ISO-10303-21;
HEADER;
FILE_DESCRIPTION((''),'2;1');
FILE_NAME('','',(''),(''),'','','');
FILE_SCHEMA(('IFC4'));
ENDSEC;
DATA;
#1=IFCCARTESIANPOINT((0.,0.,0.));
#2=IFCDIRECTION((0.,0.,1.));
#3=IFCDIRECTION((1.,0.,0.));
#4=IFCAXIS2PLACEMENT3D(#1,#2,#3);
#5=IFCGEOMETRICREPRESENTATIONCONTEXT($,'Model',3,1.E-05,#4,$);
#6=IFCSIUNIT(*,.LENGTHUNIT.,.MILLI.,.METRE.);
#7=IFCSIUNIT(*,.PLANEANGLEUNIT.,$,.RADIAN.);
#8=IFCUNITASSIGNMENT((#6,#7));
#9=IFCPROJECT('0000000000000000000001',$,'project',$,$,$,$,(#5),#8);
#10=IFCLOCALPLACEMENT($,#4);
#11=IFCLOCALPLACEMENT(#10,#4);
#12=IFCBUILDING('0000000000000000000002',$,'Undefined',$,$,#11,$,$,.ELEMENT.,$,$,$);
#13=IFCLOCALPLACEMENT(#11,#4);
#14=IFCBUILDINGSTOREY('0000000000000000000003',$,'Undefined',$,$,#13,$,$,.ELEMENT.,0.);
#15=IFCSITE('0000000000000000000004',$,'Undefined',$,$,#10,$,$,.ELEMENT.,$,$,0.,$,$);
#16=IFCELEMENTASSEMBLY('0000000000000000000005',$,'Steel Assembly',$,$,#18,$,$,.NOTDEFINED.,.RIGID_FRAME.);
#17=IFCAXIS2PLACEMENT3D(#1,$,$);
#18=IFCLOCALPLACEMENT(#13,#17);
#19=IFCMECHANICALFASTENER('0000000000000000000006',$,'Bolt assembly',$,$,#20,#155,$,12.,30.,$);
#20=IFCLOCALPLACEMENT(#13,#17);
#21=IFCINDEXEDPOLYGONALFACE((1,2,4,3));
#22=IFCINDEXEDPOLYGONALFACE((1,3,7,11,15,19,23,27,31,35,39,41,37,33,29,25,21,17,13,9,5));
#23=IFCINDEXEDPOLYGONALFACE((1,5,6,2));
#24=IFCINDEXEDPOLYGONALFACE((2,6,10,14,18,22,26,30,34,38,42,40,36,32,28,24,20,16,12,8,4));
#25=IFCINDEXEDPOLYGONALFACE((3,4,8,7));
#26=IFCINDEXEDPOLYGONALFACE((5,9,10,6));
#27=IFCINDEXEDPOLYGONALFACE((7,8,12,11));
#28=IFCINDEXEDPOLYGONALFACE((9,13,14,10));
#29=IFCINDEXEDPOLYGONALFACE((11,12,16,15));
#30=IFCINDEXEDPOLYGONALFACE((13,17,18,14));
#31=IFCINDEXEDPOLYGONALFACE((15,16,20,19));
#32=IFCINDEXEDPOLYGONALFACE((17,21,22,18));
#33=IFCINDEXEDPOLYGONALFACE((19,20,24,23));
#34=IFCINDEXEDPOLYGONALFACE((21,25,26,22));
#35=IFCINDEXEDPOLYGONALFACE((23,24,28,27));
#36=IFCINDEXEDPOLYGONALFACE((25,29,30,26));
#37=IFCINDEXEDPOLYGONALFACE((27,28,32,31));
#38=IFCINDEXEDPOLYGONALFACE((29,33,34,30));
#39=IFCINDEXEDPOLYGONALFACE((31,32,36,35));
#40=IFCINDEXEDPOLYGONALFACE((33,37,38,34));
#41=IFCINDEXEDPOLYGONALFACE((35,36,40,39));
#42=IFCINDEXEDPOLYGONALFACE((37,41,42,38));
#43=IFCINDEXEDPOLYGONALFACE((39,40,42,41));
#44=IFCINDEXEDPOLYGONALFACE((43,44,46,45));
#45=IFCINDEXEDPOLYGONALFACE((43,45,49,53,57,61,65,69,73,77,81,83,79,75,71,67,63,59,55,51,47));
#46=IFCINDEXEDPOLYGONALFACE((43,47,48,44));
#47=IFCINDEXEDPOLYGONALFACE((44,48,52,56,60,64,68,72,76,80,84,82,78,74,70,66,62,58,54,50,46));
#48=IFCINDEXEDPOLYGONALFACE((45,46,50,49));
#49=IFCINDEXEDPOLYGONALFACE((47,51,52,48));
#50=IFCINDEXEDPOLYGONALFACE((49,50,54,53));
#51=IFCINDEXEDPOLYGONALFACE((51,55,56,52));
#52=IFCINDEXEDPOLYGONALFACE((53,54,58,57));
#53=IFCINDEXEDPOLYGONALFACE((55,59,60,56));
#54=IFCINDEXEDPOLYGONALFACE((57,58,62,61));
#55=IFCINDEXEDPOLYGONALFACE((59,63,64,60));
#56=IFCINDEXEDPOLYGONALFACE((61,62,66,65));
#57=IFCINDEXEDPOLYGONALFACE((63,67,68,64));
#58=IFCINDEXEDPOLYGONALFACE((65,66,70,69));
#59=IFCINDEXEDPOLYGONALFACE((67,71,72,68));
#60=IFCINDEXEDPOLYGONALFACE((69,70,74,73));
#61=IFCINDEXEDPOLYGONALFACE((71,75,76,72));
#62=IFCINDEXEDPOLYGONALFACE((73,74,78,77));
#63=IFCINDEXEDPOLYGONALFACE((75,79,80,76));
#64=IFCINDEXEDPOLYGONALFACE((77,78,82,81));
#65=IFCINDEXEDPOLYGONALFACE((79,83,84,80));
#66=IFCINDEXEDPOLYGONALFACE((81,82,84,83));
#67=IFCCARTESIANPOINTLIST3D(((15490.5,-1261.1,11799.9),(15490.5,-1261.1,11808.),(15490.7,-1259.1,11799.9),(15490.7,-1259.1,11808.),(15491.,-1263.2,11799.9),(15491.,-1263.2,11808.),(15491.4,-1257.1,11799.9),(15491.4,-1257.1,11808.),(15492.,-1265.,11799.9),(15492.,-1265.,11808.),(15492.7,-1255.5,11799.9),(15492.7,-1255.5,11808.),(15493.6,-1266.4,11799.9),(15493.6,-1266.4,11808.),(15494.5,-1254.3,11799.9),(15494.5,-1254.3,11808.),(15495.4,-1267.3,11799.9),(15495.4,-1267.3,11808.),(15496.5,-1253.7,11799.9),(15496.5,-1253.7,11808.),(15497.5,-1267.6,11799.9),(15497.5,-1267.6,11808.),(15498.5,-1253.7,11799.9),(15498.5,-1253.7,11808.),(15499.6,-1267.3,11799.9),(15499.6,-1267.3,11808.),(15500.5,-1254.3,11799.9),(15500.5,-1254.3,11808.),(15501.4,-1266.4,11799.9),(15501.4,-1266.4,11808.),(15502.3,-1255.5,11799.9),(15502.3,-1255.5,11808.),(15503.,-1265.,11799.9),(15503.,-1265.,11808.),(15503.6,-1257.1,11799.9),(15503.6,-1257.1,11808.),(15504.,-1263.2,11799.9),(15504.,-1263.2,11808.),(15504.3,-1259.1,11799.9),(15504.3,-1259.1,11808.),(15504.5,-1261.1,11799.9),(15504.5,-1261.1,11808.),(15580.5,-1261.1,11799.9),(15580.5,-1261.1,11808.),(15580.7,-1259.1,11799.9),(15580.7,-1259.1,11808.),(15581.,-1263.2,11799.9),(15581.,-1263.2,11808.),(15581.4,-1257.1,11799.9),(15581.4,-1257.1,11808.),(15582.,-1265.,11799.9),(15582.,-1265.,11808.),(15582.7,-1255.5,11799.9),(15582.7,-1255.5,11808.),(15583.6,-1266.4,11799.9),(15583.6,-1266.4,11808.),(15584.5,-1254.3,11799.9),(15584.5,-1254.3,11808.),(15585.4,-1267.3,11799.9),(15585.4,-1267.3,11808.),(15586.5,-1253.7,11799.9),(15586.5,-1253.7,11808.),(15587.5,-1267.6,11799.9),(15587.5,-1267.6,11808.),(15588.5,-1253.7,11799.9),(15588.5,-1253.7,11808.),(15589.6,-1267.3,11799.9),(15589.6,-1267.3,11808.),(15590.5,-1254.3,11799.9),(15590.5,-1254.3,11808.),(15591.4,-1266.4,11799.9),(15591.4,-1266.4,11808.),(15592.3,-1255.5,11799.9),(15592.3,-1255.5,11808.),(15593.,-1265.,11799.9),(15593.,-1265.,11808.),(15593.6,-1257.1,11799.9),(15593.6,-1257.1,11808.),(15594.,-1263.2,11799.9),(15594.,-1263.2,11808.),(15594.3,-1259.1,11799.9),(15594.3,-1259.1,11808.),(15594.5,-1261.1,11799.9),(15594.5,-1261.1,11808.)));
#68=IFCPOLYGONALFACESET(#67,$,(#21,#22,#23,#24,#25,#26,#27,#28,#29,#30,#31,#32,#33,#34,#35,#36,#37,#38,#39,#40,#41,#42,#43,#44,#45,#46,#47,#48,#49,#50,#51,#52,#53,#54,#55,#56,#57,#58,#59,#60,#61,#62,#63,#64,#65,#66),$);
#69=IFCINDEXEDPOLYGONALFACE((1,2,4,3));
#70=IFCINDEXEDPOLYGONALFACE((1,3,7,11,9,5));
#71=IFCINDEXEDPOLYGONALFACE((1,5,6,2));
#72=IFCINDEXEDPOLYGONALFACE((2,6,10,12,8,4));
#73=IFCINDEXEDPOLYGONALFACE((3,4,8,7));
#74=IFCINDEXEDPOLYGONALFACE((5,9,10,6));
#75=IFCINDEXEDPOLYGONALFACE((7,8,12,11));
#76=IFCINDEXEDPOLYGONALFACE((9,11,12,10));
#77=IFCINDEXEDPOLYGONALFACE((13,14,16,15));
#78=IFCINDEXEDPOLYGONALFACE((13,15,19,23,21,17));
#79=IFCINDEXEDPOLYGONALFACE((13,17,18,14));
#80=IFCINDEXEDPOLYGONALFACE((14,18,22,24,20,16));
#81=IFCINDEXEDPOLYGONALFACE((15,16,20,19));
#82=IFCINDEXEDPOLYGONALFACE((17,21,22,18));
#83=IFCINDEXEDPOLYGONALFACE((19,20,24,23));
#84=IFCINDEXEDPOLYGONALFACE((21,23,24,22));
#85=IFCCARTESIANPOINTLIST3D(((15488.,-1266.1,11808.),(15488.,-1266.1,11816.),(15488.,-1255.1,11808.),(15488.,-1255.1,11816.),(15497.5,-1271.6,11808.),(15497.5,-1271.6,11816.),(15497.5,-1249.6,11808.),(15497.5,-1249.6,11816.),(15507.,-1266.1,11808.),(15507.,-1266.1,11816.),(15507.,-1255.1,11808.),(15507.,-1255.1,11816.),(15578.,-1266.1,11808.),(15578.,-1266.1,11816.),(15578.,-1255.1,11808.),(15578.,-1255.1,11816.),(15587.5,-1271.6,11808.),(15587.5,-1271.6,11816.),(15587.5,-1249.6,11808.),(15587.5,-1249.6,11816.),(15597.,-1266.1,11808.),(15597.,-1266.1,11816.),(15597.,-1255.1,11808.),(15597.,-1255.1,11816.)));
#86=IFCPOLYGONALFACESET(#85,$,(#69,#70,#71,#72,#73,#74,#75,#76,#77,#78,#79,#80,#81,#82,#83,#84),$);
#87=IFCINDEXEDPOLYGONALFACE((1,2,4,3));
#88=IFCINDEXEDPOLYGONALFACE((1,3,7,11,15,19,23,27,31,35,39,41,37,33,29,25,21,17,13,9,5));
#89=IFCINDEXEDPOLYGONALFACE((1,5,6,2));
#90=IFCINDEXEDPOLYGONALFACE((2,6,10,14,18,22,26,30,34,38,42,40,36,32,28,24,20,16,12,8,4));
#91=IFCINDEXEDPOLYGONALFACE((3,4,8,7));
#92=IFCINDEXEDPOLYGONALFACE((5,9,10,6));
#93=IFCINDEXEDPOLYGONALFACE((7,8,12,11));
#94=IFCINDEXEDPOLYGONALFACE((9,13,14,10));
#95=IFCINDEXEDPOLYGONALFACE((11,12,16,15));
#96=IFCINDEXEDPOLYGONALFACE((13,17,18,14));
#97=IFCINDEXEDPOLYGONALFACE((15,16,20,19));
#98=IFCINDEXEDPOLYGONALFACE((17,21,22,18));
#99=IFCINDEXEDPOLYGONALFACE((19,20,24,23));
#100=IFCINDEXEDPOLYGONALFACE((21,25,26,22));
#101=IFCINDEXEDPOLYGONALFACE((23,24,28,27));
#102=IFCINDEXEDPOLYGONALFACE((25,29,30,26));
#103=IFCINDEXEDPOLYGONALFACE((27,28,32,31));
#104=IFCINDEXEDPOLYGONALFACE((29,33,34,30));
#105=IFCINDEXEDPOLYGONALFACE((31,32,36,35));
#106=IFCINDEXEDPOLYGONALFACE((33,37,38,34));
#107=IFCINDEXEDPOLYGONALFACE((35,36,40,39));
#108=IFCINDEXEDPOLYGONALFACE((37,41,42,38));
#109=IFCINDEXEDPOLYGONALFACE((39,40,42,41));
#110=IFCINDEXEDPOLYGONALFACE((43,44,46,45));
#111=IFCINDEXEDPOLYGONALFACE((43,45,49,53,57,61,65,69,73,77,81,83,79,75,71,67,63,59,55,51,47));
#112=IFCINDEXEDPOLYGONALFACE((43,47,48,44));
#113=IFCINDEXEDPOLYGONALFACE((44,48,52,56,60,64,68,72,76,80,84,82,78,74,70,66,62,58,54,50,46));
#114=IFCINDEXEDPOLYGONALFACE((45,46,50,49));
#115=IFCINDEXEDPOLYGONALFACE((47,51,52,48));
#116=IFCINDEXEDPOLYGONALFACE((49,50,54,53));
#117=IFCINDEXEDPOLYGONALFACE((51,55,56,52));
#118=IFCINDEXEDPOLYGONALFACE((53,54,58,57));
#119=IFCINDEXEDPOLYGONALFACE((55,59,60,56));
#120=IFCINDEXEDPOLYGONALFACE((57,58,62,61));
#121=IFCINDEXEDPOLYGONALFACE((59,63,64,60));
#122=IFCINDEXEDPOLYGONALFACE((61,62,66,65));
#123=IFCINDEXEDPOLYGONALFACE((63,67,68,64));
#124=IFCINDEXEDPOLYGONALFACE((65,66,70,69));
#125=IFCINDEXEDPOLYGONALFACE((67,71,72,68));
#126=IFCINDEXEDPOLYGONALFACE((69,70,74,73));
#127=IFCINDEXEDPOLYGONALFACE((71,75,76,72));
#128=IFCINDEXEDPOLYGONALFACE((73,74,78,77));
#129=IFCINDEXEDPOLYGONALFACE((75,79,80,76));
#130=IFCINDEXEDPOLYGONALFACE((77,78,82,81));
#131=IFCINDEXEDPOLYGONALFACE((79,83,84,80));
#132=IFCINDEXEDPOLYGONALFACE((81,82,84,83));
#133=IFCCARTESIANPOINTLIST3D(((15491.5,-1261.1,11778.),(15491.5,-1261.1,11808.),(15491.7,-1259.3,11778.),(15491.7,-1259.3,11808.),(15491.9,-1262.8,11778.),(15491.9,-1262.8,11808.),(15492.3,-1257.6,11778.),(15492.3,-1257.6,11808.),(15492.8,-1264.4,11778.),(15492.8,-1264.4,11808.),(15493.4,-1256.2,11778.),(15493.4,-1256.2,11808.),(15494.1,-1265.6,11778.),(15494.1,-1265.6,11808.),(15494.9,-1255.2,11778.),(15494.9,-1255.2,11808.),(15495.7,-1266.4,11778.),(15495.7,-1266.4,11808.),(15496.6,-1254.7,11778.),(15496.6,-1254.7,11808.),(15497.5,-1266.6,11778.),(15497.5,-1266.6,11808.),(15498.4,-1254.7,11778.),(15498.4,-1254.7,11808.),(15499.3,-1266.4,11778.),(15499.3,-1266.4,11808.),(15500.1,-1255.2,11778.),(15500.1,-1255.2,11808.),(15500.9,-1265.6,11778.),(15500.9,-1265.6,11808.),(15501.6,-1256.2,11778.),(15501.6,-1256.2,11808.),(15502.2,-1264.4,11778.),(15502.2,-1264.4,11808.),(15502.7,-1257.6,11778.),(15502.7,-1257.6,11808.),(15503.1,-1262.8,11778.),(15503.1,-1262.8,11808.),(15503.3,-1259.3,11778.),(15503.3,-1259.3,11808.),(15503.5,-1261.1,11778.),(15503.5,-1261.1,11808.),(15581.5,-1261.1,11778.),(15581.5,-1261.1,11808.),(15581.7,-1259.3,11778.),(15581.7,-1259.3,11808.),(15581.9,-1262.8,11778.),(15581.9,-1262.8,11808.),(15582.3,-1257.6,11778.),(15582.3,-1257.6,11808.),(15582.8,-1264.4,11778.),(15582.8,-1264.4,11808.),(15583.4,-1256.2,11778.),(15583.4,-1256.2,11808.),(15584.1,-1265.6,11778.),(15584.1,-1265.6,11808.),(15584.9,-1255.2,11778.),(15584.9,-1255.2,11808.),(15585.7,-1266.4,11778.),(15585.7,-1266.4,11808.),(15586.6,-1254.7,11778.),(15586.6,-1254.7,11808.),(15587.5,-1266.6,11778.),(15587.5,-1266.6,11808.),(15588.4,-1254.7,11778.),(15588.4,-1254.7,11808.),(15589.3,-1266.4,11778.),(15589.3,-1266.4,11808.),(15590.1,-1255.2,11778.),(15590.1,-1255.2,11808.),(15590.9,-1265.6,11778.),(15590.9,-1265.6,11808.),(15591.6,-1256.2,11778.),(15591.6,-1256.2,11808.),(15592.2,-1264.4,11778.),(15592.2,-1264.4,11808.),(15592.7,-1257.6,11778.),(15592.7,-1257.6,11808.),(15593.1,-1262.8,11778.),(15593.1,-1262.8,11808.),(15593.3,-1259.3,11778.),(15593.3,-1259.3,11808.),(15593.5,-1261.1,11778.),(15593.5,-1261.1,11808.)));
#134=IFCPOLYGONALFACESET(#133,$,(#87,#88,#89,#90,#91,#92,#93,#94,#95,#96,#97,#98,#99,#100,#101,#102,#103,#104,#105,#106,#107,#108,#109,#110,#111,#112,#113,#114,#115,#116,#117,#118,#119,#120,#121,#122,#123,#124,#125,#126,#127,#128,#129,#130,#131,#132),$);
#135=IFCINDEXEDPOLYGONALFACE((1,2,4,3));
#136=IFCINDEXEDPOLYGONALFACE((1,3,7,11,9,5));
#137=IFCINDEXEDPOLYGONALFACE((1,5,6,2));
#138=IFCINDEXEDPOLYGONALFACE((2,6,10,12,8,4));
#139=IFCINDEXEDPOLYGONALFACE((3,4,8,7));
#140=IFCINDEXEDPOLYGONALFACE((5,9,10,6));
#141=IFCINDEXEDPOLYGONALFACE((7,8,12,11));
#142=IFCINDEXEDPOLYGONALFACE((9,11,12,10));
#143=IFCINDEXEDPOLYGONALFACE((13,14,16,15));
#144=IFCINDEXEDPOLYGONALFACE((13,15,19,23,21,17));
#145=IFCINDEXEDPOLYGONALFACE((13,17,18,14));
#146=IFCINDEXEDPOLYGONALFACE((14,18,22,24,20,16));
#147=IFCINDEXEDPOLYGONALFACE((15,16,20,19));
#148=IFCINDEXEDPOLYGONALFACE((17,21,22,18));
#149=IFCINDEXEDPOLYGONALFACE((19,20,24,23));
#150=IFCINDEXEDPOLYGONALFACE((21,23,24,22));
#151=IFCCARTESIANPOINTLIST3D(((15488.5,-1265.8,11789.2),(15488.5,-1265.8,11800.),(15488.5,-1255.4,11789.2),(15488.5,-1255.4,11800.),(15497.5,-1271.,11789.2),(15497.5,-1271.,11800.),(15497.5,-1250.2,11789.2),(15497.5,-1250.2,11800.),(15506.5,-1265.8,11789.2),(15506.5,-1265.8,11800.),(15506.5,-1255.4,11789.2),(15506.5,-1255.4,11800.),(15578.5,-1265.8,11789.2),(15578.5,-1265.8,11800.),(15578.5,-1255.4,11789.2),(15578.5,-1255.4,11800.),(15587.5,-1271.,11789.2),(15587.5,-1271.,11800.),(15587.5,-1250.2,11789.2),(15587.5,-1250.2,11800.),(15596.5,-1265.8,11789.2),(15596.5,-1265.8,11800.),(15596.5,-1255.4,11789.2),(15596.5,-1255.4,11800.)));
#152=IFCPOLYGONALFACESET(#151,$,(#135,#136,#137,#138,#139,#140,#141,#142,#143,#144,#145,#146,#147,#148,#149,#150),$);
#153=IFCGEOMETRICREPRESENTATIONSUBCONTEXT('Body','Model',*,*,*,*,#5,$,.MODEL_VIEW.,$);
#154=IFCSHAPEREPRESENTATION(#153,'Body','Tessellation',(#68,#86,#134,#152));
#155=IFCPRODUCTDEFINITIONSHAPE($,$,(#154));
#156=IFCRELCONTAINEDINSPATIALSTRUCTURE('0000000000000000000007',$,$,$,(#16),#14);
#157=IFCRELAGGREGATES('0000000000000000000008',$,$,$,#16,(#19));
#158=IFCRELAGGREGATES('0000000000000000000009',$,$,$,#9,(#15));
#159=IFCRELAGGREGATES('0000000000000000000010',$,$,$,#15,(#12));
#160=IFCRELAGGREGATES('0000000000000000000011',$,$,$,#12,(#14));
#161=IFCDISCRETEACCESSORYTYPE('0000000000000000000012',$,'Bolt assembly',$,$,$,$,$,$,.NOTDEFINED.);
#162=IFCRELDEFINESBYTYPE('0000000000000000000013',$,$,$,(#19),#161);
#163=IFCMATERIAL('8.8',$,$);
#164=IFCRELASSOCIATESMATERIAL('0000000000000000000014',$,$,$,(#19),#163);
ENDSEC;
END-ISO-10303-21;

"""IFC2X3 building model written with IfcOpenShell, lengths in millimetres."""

from ifc_helpers import new_model, si_unit, frame, origin_with_axes, origin_2d_with_axis, place, context, subcontext, project, spatial, polyline, circle, outline, extrude, source, transform, mapped, material, type_object, element, aggregate, save


model = new_model("IFC2X3")

# Units and contexts
model_context = context("Model", 3, precision=1e-05, world=origin_with_axes())
body_context = subcontext(model_context, "Body", "Model", "MODEL_VIEW")
ifc_project = project(units=[si_unit("LENGTHUNIT", "METRE", prefix="MILLI"), si_unit("PLANEANGLEUNIT", "RADIAN")], contexts=[model_context])

# Site, building, storey
site_placement = place(None, origin_with_axes())
site = spatial("IfcSite", under=ifc_project, at=site_placement, Name="Undefined", CompositionType="ELEMENT", RefElevation=0.0)
building_placement = place(site_placement, origin_with_axes())
building = spatial("IfcBuilding", under=site, at=building_placement, Name="Undefined", CompositionType="ELEMENT")
storey_placement = place(building_placement, origin_with_axes())
storey = spatial("IfcBuildingStorey", under=building, at=storey_placement, Name="Undefined", CompositionType="ELEMENT", Elevation=0.0)

# Element assembly, mechanical fastener
assembly_1_placement = place(storey_placement, origin_with_axes())
assembly_1 = element("IfcElementAssembly", 1, at=assembly_1_placement, inside=storey, Name="Steel Assembly", AssemblyPlace="NOTDEFINED", PredefinedType="RIGID_FRAME")
ifc_material_1 = material(Name="8.8")
discrete_accessory_type_1 = type_object("IfcDiscreteAccessoryType", Name="Bolt assembly")
shared_shape_1 = source(origin_with_axes(), body_context, "Body", "SweptSolid", [
    extrude(circle(Radius=7.0, at=origin_2d_with_axis()), frame((0.0, 0.0, 0.0), z_axis=(0.0, 1.0, 0.0), x_axis=(1.0, 0.0, 0.0)), (0.0, 0.0, 1.0), 8.1),
    extrude(outline(polyline([(11.0, 0.0), (5.5, 9.5), (-5.5, 9.5), (-11.0, 0.0), (-5.5, -9.5), (5.5, -9.5), (11.0, 0.0)])), frame((0.0, -8.0, 0.0), z_axis=(0.0, 1.0, 0.0), x_axis=(1.0, 0.0, 0.0)), (0.0, 0.0, 1.0), 8.0),
    extrude(circle(Radius=6.0, at=origin_2d_with_axis()), frame((0.0, 0.0, 0.0), z_axis=(0.0, 1.0, 0.0), x_axis=(1.0, 0.0, 0.0)), (0.0, 0.0, 1.0), 30.0),
    extrude(outline(polyline([(10.4, 0.0), (5.2, 9.0), (-5.2, 9.0), (-10.4, 0.0), (-5.2, -9.0), (5.2, -9.0), (10.4, 0.0)])), frame((0.0, 8.0, 0.0), z_axis=(0.0, 1.0, 0.0), x_axis=(1.0, 0.0, 0.0)), (0.0, 0.0, 1.0), 10.8),
])
mechanical_fastener_1_placement = place(assembly_1_placement, frame((15542.5, -1240.6, 11808.0), z_axis=(1.0, 0.0, 0.0), x_axis=(0.0, -1.0, 0.0)))
mechanical_fastener_1 = element("IfcMechanicalFastener", 2, at=mechanical_fastener_1_placement, type_object=discrete_accessory_type_1, material=ifc_material_1, Name="Bolt assembly", NominalDiameter=12.0, NominalLength=30.0, context=body_context, shape_type="MappedRepresentation", body=[
    mapped(shared_shape_1, transform((20.0, 0.0, -45.0))),
    mapped(shared_shape_1, transform((20.0, 0.0, 45.0))),
])

aggregate(assembly_1, [mechanical_fastener_1])

save(model, "model.ifc")
